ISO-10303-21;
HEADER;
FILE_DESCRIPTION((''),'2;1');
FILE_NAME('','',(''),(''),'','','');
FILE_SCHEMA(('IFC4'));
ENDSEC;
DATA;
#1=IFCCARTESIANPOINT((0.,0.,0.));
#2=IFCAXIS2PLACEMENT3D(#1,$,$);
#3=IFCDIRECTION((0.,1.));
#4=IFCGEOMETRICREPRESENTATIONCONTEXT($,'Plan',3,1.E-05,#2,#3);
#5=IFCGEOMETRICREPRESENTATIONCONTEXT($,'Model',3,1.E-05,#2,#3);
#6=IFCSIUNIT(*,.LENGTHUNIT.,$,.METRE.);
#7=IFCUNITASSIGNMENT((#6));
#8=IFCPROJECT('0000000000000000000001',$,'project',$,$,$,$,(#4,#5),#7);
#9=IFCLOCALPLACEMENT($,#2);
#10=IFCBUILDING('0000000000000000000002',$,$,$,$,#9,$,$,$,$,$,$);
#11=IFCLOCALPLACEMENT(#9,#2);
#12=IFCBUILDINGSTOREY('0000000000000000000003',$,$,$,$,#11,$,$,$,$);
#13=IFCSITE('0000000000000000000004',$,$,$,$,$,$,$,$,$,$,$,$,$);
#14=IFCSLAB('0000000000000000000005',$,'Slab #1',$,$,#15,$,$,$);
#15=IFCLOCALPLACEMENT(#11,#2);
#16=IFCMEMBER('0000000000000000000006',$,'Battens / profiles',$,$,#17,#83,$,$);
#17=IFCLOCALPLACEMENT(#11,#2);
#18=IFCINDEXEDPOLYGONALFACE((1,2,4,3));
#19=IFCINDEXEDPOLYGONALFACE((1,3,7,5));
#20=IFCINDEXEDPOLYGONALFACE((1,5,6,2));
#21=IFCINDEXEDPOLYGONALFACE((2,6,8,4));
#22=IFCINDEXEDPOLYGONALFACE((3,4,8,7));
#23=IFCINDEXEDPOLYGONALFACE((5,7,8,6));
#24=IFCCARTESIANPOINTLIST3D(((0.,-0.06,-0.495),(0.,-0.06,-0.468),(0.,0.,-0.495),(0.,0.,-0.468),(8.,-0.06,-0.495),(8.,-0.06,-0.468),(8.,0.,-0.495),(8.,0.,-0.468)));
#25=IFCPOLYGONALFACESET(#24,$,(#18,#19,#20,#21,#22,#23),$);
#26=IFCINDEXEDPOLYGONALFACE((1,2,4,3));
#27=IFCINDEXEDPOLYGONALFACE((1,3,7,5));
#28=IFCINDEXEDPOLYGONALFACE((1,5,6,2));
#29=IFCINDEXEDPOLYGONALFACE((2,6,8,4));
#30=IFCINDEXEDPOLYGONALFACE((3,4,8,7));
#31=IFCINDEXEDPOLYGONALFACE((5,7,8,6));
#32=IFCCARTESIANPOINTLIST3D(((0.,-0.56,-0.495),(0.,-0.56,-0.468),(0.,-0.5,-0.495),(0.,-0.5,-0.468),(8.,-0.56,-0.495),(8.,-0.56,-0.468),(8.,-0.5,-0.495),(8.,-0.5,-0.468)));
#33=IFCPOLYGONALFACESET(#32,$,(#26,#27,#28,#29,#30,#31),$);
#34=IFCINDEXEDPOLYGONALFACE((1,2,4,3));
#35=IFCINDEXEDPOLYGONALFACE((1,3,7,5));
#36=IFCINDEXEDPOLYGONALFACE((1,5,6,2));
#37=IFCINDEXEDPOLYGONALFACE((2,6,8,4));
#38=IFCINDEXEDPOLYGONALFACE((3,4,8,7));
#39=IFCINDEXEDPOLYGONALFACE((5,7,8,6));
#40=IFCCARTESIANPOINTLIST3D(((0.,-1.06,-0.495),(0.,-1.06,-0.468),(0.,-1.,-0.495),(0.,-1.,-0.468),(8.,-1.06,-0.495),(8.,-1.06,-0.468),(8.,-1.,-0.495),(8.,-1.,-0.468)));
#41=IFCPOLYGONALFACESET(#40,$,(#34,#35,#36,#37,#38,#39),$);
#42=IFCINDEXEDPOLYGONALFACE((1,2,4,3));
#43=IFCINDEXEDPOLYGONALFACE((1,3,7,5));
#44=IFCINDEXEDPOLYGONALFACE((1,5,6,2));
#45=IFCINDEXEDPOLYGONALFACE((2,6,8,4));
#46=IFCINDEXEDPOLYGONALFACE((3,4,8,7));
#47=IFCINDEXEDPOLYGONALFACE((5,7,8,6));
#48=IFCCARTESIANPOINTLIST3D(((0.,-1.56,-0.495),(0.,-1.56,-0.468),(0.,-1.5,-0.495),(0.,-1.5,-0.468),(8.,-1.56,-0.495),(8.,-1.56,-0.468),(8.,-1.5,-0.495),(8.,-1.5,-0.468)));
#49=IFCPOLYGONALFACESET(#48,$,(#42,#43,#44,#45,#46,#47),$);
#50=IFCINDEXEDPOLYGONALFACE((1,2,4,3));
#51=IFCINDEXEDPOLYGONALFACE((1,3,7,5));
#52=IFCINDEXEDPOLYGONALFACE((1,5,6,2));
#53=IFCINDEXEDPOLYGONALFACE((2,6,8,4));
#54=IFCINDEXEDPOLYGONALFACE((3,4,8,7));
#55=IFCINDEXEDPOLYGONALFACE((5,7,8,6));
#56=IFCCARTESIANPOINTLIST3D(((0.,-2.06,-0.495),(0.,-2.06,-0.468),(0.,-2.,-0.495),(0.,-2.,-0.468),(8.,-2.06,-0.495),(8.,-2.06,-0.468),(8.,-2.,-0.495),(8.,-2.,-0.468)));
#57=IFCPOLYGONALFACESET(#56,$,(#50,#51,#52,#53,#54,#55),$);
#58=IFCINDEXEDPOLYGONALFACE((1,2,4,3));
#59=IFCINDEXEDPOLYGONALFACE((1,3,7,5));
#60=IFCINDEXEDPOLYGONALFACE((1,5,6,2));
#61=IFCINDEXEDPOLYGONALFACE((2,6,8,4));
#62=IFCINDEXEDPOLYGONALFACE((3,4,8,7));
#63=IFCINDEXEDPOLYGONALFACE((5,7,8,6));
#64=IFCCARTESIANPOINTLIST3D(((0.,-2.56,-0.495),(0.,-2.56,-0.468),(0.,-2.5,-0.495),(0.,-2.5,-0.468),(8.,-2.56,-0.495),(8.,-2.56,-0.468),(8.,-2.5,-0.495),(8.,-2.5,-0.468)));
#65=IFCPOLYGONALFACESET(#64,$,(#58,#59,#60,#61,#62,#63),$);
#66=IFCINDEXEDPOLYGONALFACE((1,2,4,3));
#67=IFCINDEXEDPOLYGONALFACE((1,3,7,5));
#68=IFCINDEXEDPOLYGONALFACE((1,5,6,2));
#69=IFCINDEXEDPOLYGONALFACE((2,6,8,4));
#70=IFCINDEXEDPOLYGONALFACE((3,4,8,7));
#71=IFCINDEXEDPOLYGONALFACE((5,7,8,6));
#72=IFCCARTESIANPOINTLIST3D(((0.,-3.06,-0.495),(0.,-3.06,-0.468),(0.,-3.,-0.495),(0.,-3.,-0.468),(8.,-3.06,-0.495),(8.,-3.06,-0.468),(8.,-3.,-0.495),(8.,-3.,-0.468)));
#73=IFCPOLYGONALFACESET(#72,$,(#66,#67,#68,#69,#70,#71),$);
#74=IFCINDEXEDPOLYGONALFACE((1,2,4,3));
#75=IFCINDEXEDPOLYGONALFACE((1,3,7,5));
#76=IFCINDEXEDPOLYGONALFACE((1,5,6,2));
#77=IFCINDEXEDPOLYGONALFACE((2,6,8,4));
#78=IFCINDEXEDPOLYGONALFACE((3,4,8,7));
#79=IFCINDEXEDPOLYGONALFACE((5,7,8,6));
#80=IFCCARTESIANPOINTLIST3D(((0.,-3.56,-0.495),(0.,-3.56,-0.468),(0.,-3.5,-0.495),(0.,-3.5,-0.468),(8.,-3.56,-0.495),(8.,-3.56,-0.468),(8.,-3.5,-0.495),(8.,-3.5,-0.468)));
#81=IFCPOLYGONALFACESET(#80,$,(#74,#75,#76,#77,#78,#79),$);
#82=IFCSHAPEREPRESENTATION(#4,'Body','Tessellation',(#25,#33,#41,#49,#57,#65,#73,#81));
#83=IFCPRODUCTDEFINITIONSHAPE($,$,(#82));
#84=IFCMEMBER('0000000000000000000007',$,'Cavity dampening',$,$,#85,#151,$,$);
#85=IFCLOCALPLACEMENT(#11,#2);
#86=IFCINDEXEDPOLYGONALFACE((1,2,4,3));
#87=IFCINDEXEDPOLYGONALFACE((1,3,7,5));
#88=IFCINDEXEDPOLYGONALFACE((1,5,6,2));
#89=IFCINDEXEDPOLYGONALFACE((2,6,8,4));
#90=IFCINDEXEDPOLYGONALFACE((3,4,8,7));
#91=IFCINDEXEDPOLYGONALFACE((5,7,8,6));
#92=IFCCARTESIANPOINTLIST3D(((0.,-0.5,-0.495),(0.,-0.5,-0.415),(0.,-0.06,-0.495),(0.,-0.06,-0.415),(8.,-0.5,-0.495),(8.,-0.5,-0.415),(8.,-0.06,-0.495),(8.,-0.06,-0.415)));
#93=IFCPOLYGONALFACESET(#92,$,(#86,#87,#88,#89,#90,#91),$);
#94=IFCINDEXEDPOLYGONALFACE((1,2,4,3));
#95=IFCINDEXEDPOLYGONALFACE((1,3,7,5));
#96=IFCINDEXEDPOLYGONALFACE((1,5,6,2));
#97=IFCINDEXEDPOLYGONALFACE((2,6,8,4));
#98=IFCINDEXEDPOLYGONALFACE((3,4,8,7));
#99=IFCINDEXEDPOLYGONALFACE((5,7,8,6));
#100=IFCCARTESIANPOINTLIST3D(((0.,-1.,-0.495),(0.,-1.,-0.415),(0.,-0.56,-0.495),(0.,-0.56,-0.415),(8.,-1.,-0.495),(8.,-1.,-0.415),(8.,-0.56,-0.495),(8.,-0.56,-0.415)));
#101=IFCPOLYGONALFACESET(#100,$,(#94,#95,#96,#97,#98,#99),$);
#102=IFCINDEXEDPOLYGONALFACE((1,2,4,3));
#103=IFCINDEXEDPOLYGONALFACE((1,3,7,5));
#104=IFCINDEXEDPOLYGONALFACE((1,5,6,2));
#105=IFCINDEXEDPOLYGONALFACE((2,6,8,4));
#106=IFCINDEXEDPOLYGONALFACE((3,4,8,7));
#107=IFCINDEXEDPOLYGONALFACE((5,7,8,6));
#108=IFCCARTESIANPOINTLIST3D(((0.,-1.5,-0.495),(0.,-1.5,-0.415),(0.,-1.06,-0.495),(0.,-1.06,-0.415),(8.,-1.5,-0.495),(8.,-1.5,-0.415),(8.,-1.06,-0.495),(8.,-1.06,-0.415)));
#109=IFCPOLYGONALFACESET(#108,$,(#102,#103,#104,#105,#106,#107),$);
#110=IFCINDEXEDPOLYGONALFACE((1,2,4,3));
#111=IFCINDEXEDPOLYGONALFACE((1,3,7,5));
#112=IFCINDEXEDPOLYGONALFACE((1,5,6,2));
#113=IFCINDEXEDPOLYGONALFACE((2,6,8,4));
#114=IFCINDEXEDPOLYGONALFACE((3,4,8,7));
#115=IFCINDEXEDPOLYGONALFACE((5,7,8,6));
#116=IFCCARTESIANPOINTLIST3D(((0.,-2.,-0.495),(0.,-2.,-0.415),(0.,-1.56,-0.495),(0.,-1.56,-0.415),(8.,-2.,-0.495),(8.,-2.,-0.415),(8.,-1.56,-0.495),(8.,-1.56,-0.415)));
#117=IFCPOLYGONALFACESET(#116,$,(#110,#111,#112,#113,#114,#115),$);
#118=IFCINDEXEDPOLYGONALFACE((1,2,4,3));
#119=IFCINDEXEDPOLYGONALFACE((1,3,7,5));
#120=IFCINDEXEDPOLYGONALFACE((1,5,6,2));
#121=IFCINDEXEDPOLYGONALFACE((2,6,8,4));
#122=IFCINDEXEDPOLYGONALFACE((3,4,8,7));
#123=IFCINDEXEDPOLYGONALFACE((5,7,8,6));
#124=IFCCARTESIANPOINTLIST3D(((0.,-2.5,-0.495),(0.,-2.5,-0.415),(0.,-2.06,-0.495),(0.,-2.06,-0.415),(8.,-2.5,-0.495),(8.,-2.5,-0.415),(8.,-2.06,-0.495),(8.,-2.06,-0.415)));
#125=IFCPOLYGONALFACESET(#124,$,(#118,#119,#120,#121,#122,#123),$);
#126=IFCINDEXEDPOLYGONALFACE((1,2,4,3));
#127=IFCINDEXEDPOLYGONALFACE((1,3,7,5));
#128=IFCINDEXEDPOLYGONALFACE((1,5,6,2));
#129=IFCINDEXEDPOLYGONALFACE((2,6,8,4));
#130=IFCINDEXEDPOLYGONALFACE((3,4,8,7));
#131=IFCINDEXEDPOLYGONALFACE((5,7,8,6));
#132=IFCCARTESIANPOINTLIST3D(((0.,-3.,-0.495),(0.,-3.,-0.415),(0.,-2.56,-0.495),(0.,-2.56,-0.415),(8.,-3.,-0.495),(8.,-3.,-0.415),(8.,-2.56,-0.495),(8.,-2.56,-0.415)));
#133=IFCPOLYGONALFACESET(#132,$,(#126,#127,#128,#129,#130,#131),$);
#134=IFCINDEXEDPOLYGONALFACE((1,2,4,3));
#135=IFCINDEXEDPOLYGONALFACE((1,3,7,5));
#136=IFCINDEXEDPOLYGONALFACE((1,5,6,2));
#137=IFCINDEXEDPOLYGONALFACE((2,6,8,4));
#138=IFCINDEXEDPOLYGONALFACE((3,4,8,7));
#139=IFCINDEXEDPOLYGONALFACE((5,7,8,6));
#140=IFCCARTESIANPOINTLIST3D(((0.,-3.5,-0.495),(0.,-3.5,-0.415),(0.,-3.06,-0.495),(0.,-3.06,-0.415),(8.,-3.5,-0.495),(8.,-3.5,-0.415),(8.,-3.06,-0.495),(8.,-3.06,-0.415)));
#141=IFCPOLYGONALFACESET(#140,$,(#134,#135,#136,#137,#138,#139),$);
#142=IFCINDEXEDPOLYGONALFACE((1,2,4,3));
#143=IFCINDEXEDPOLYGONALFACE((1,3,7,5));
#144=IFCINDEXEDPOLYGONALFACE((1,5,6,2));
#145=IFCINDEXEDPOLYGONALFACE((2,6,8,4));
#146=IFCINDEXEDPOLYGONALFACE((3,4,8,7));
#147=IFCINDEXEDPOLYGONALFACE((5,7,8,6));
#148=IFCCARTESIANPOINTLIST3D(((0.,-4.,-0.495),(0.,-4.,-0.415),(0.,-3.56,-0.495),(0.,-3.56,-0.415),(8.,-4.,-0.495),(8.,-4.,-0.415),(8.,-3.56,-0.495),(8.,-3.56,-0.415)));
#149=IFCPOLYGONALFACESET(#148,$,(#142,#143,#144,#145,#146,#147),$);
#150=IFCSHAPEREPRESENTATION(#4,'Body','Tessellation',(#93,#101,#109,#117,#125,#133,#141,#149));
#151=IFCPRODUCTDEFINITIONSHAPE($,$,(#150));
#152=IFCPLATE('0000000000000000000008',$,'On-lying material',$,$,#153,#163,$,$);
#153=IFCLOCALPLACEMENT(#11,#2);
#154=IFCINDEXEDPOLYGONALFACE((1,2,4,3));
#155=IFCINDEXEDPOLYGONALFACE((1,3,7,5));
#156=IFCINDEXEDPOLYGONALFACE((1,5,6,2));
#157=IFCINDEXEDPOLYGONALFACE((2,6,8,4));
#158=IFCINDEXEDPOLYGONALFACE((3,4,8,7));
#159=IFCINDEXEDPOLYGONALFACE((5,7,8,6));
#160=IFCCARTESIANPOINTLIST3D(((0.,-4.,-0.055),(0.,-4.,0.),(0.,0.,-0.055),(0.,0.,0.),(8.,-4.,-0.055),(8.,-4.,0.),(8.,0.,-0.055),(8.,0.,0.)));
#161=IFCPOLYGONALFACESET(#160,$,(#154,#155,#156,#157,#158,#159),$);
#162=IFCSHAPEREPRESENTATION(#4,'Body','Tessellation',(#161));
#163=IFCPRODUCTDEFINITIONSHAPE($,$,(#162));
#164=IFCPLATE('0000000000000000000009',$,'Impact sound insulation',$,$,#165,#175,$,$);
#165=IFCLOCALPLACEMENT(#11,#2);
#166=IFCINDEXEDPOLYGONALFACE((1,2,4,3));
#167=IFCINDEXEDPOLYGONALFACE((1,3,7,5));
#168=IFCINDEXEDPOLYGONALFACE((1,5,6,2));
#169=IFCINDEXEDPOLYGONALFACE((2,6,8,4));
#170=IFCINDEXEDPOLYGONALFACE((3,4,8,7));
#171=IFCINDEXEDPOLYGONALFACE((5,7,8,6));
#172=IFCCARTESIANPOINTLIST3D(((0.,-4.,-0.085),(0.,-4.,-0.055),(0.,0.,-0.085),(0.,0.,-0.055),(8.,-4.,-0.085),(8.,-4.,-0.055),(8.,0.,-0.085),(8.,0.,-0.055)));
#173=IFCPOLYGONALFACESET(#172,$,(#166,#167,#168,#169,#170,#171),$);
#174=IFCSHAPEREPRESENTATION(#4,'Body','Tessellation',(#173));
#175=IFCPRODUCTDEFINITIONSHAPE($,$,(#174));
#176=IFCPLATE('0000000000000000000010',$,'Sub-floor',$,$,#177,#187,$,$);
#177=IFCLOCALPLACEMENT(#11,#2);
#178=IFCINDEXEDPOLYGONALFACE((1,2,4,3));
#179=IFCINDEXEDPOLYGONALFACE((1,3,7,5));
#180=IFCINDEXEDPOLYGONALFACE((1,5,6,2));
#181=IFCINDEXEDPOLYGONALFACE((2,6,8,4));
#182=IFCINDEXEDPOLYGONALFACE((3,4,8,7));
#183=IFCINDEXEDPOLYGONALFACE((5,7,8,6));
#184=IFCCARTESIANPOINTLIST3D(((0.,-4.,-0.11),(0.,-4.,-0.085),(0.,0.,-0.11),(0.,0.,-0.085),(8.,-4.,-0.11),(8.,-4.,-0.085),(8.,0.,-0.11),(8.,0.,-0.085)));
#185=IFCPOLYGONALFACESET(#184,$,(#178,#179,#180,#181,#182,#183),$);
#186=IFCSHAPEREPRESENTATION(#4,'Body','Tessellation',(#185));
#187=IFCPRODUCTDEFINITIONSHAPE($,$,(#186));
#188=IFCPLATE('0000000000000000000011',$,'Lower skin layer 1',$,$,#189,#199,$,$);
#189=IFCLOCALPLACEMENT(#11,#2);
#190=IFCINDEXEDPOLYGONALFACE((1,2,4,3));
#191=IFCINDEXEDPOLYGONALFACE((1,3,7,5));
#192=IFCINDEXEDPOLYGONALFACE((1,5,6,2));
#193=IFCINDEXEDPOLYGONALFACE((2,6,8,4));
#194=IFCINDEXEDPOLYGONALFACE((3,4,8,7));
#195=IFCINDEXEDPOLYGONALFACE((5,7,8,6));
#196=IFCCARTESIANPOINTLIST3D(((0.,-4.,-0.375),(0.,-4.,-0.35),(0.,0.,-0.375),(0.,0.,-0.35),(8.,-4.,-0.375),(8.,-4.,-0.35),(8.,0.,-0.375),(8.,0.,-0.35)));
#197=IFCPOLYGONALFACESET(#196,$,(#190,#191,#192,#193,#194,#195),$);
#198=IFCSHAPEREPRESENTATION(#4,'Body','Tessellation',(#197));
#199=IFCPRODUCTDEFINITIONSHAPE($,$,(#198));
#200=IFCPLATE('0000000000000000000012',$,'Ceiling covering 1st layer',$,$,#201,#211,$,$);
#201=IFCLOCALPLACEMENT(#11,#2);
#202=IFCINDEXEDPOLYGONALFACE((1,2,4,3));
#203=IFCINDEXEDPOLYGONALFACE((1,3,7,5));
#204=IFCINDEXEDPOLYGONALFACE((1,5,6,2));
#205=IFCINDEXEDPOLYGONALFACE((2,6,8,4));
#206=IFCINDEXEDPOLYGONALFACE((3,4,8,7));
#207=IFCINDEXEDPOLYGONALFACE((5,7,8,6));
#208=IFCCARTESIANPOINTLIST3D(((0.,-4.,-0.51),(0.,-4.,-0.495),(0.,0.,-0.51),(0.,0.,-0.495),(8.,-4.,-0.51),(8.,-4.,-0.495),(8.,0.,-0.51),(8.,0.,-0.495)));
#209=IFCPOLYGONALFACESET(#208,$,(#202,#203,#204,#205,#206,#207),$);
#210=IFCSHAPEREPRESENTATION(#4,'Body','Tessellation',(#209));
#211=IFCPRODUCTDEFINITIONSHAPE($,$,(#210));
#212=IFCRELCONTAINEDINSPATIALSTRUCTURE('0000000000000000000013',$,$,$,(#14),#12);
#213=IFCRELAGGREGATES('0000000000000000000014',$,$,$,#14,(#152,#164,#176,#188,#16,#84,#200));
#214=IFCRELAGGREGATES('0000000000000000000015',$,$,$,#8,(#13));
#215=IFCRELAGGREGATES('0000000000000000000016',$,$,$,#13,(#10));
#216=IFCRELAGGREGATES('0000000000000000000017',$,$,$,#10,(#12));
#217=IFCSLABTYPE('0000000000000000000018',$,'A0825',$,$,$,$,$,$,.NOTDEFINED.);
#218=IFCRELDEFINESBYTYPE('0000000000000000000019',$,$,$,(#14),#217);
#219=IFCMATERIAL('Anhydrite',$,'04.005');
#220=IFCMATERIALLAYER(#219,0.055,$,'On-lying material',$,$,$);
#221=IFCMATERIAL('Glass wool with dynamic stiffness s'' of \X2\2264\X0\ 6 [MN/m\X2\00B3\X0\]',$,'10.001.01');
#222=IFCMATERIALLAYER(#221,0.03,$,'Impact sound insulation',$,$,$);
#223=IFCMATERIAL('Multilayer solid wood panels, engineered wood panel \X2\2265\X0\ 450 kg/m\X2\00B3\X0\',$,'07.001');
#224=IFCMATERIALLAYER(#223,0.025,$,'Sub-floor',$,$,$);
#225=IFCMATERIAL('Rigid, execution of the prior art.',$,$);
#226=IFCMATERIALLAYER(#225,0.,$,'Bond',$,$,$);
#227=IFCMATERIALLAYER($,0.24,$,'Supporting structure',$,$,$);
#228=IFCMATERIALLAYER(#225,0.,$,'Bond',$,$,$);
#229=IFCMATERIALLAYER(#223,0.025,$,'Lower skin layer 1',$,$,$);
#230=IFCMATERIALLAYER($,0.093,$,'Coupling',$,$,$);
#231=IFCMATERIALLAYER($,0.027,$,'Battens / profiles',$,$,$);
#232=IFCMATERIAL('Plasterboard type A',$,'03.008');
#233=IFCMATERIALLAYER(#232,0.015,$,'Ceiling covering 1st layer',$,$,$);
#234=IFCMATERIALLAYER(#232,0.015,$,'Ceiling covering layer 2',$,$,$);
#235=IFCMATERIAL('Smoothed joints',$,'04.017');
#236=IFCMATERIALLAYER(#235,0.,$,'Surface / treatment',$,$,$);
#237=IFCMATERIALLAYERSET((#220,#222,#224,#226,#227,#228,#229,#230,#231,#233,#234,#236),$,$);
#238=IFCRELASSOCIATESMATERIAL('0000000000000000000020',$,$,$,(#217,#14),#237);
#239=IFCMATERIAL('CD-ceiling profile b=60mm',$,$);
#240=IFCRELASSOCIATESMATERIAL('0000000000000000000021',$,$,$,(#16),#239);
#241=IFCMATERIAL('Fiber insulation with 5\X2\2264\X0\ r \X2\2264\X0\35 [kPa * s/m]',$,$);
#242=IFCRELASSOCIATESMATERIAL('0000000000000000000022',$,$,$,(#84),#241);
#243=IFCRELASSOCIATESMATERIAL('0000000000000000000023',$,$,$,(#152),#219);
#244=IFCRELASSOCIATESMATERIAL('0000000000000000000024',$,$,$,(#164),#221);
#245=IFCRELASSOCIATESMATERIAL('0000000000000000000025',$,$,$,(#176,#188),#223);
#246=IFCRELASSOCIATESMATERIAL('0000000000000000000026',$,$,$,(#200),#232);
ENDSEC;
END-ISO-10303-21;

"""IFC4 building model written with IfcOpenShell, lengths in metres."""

from ifc_helpers import new_model, si_unit, direction, frame, frame_2d, origin, origin_with_axes, place, context, project, spatial, rectangle, extrude, material, layer, layer_set, type_object, element, aggregate, save


model = new_model("IFC4")

# Units and contexts
plan_context = context("Plan", 3, precision=1e-05, world=origin(), true_north=direction((0.0, 1.0)))
model_context = context("Model", 3, precision=1e-05, world=origin(), true_north=direction((0.0, 1.0)))
ifc_project = project(units=[si_unit("LENGTHUNIT", "METRE")], contexts=[plan_context, model_context])

# Site, building, storey
site = spatial("IfcSite", under=ifc_project)
building_placement = place(None, origin())
building = spatial("IfcBuilding", under=site, at=building_placement)
storey_placement = place(building_placement, origin())
storey = spatial("IfcBuildingStorey", under=building, at=storey_placement)

# Slab, members, plates
ifc_material_1 = material(Name="Anhydrite", Category="04.005")
ifc_layer_1 = layer(ifc_material_1, 0.055, Name="On-lying material")
ifc_material_2 = material(Name="Glass wool with dynamic stiffness s' of ≤ 6 [MN/m³]", Category="10.001.01")
ifc_layer_2 = layer(ifc_material_2, 0.03, Name="Impact sound insulation")
ifc_material_3 = material(Name="Multilayer solid wood panels, engineered wood panel ≥ 450 kg/m³", Category="07.001")
ifc_layer_3 = layer(ifc_material_3, 0.025, Name="Sub-floor")
ifc_material_4 = material(Name="Rigid, execution of the prior art.")
ifc_layer_4 = layer(ifc_material_4, 0.0, Name="Bond")
ifc_layer_5 = layer(None, 0.24, Name="Supporting structure")
ifc_layer_6 = layer(ifc_material_4, 0.0, Name="Bond")
ifc_layer_7 = layer(ifc_material_3, 0.025, Name="Lower skin layer 1")
ifc_layer_8 = layer(None, 0.093, Name="Coupling")
ifc_layer_9 = layer(None, 0.027, Name="Battens / profiles")
ifc_material_5 = material(Name="Plasterboard type A", Category="03.008")
ifc_layer_10 = layer(ifc_material_5, 0.015, Name="Ceiling covering 1st layer")
ifc_layer_11 = layer(ifc_material_5, 0.015, Name="Ceiling covering layer 2")
ifc_material_6 = material(Name="Smoothed joints", Category="04.017")
ifc_layer_12 = layer(ifc_material_6, 0.0, Name="Surface / treatment")
ifc_layer_set = layer_set([ifc_layer_1, ifc_layer_2, ifc_layer_3, ifc_layer_4, ifc_layer_5, ifc_layer_6, ifc_layer_7, ifc_layer_8, ifc_layer_9, ifc_layer_10, ifc_layer_11, ifc_layer_12])
slab_type = type_object("IfcSlabType", Name="A0825", PredefinedType="NOTDEFINED", material=ifc_layer_set)
slab_placement = place(None, frame((0.0, 0.0, 0.0), z_axis=(0.0, 0.0, -1.0), x_axis=(1.0, 0.0, 0.0)))
slab = element("IfcSlab", 1, at=slab_placement, inside=storey, type_object=slab_type, material=ifc_layer_set, Name="Slab #1")
ifc_material_7 = material(Name="CD-ceiling profile b=60mm")
member_1_placement = place(slab_placement, origin())
member_1 = element("IfcMember", 2, at=member_1_placement, material=ifc_material_7, Name="Battens / profiles", context=plan_context, shape_type="SweptSolid", body=[
    extrude(rectangle(XDim=0.06, YDim=0.027, at=frame_2d((0.03, 0.0135), x_axis=(1.0, 0.0))), frame((0.0, 0.0, 0.468), z_axis=(1.0, 0.0, 0.0), x_axis=(0.0, 1.0, 0.0)), (0.0, 0.0, 1.0), 8.0),
    extrude(rectangle(XDim=0.06, YDim=0.027, at=frame_2d((0.03, 0.0135), x_axis=(1.0, 0.0))), frame((0.0, 0.5, 0.468), z_axis=(1.0, 0.0, 0.0), x_axis=(0.0, 1.0, 0.0)), (0.0, 0.0, 1.0), 8.0),
    extrude(rectangle(XDim=0.06, YDim=0.027, at=frame_2d((0.03, 0.0135), x_axis=(1.0, 0.0))), frame((0.0, 1.0, 0.468), z_axis=(1.0, 0.0, 0.0), x_axis=(0.0, 1.0, 0.0)), (0.0, 0.0, 1.0), 8.0),
    extrude(rectangle(XDim=0.06, YDim=0.027, at=frame_2d((0.03, 0.0135), x_axis=(1.0, 0.0))), frame((0.0, 1.5, 0.468), z_axis=(1.0, 0.0, 0.0), x_axis=(0.0, 1.0, 0.0)), (0.0, 0.0, 1.0), 8.0),
    extrude(rectangle(XDim=0.06, YDim=0.027, at=frame_2d((0.03, 0.0135), x_axis=(1.0, 0.0))), frame((0.0, 2.0, 0.468), z_axis=(1.0, 0.0, 0.0), x_axis=(0.0, 1.0, 0.0)), (0.0, 0.0, 1.0), 8.0),
    extrude(rectangle(XDim=0.06, YDim=0.027, at=frame_2d((0.03, 0.0135), x_axis=(1.0, 0.0))), frame((0.0, 2.5, 0.468), z_axis=(1.0, 0.0, 0.0), x_axis=(0.0, 1.0, 0.0)), (0.0, 0.0, 1.0), 8.0),
    extrude(rectangle(XDim=0.06, YDim=0.027, at=frame_2d((0.03, 0.0135), x_axis=(1.0, 0.0))), frame((0.0, 3.0, 0.468), z_axis=(1.0, 0.0, 0.0), x_axis=(0.0, 1.0, 0.0)), (0.0, 0.0, 1.0), 8.0),
    extrude(rectangle(XDim=0.06, YDim=0.027, at=frame_2d((0.03, 0.0135), x_axis=(1.0, 0.0))), frame((0.0, 3.5, 0.468), z_axis=(1.0, 0.0, 0.0), x_axis=(0.0, 1.0, 0.0)), (0.0, 0.0, 1.0), 8.0),
])
ifc_material_8 = material(Name="Fiber insulation with 5≤ r ≤35 [kPa * s/m]")
member_2_placement = place(slab_placement, origin())
member_2 = element("IfcMember", 3, at=member_2_placement, material=ifc_material_8, Name="Cavity dampening", context=plan_context, shape_type="SweptSolid", body=[
    extrude(rectangle(XDim=0.44, YDim=0.08, at=frame_2d((0.22, 0.04), x_axis=(1.0, 0.0))), frame((0.0, 0.06, 0.415), z_axis=(1.0, 0.0, 0.0), x_axis=(0.0, 1.0, 0.0)), (0.0, 0.0, 1.0), 8.0),
    extrude(rectangle(XDim=0.44, YDim=0.08, at=frame_2d((0.22, 0.04), x_axis=(1.0, 0.0))), frame((0.0, 0.56, 0.415), z_axis=(1.0, 0.0, 0.0), x_axis=(0.0, 1.0, 0.0)), (0.0, 0.0, 1.0), 8.0),
    extrude(rectangle(XDim=0.44, YDim=0.08, at=frame_2d((0.22, 0.04), x_axis=(1.0, 0.0))), frame((0.0, 1.06, 0.415), z_axis=(1.0, 0.0, 0.0), x_axis=(0.0, 1.0, 0.0)), (0.0, 0.0, 1.0), 8.0),
    extrude(rectangle(XDim=0.44, YDim=0.08, at=frame_2d((0.22, 0.04), x_axis=(1.0, 0.0))), frame((0.0, 1.56, 0.415), z_axis=(1.0, 0.0, 0.0), x_axis=(0.0, 1.0, 0.0)), (0.0, 0.0, 1.0), 8.0),
    extrude(rectangle(XDim=0.44, YDim=0.08, at=frame_2d((0.22, 0.04), x_axis=(1.0, 0.0))), frame((0.0, 2.06, 0.415), z_axis=(1.0, 0.0, 0.0), x_axis=(0.0, 1.0, 0.0)), (0.0, 0.0, 1.0), 8.0),
    extrude(rectangle(XDim=0.44, YDim=0.08, at=frame_2d((0.22, 0.04), x_axis=(1.0, 0.0))), frame((0.0, 2.56, 0.415), z_axis=(1.0, 0.0, 0.0), x_axis=(0.0, 1.0, 0.0)), (0.0, 0.0, 1.0), 8.0),
    extrude(rectangle(XDim=0.44, YDim=0.08, at=frame_2d((0.22, 0.04), x_axis=(1.0, 0.0))), frame((0.0, 3.06, 0.415), z_axis=(1.0, 0.0, 0.0), x_axis=(0.0, 1.0, 0.0)), (0.0, 0.0, 1.0), 8.0),
    extrude(rectangle(XDim=0.44, YDim=0.08, at=frame_2d((0.22, 0.04), x_axis=(1.0, 0.0))), frame((0.0, 3.56, 0.415), z_axis=(1.0, 0.0, 0.0), x_axis=(0.0, 1.0, 0.0)), (0.0, 0.0, 1.0), 8.0),
])
plate_1_placement = place(slab_placement, origin())
plate_1 = element("IfcPlate", 4, at=plate_1_placement, material=ifc_material_1, Name="On-lying material", context=plan_context, shape_type="SweptSolid", body=[
    extrude(rectangle(XDim=8.0, YDim=4.0, at=frame_2d((4.0, 2.0), x_axis=(1.0, 0.0))), origin_with_axes(), (0.0, 0.0, 1.0), 0.055),
])
plate_2_placement = place(slab_placement, origin())
plate_2 = element("IfcPlate", 5, at=plate_2_placement, material=ifc_material_2, Name="Impact sound insulation", context=plan_context, shape_type="SweptSolid", body=[
    extrude(rectangle(XDim=8.0, YDim=4.0, at=frame_2d((4.0, 2.0), x_axis=(1.0, 0.0))), frame((0.0, 0.0, 0.055), z_axis=(0.0, 0.0, 1.0), x_axis=(1.0, 0.0, 0.0)), (0.0, 0.0, 1.0), 0.03),
])
plate_3_placement = place(slab_placement, origin())
plate_3 = element("IfcPlate", 6, at=plate_3_placement, material=ifc_material_3, Name="Sub-floor", context=plan_context, shape_type="SweptSolid", body=[
    extrude(rectangle(XDim=8.0, YDim=4.0, at=frame_2d((4.0, 2.0), x_axis=(1.0, 0.0))), frame((0.0, 0.0, 0.085), z_axis=(0.0, 0.0, 1.0), x_axis=(1.0, 0.0, 0.0)), (0.0, 0.0, 1.0), 0.025),
])
plate_4_placement = place(slab_placement, origin())
plate_4 = element("IfcPlate", 7, at=plate_4_placement, material=ifc_material_3, Name="Lower skin layer 1", context=plan_context, shape_type="SweptSolid", body=[
    extrude(rectangle(XDim=8.0, YDim=4.0, at=frame_2d((4.0, 2.0), x_axis=(1.0, 0.0))), frame((0.0, 0.0, 0.35), z_axis=(0.0, 0.0, 1.0), x_axis=(1.0, 0.0, 0.0)), (0.0, 0.0, 1.0), 0.025),
])
plate_5_placement = place(slab_placement, origin())
plate_5 = element("IfcPlate", 8, at=plate_5_placement, material=ifc_material_5, Name="Ceiling covering 1st layer", context=plan_context, shape_type="SweptSolid", body=[
    extrude(rectangle(XDim=8.0, YDim=4.0, at=frame_2d((4.0, 2.0), x_axis=(1.0, 0.0))), frame((0.0, 0.0, 0.495), z_axis=(0.0, 0.0, 1.0), x_axis=(1.0, 0.0, 0.0)), (0.0, 0.0, 1.0), 0.015),
])
aggregate(slab, [plate_1, plate_2, plate_3, plate_4, member_1, member_2, plate_5])

save(model, "model.ifc")
